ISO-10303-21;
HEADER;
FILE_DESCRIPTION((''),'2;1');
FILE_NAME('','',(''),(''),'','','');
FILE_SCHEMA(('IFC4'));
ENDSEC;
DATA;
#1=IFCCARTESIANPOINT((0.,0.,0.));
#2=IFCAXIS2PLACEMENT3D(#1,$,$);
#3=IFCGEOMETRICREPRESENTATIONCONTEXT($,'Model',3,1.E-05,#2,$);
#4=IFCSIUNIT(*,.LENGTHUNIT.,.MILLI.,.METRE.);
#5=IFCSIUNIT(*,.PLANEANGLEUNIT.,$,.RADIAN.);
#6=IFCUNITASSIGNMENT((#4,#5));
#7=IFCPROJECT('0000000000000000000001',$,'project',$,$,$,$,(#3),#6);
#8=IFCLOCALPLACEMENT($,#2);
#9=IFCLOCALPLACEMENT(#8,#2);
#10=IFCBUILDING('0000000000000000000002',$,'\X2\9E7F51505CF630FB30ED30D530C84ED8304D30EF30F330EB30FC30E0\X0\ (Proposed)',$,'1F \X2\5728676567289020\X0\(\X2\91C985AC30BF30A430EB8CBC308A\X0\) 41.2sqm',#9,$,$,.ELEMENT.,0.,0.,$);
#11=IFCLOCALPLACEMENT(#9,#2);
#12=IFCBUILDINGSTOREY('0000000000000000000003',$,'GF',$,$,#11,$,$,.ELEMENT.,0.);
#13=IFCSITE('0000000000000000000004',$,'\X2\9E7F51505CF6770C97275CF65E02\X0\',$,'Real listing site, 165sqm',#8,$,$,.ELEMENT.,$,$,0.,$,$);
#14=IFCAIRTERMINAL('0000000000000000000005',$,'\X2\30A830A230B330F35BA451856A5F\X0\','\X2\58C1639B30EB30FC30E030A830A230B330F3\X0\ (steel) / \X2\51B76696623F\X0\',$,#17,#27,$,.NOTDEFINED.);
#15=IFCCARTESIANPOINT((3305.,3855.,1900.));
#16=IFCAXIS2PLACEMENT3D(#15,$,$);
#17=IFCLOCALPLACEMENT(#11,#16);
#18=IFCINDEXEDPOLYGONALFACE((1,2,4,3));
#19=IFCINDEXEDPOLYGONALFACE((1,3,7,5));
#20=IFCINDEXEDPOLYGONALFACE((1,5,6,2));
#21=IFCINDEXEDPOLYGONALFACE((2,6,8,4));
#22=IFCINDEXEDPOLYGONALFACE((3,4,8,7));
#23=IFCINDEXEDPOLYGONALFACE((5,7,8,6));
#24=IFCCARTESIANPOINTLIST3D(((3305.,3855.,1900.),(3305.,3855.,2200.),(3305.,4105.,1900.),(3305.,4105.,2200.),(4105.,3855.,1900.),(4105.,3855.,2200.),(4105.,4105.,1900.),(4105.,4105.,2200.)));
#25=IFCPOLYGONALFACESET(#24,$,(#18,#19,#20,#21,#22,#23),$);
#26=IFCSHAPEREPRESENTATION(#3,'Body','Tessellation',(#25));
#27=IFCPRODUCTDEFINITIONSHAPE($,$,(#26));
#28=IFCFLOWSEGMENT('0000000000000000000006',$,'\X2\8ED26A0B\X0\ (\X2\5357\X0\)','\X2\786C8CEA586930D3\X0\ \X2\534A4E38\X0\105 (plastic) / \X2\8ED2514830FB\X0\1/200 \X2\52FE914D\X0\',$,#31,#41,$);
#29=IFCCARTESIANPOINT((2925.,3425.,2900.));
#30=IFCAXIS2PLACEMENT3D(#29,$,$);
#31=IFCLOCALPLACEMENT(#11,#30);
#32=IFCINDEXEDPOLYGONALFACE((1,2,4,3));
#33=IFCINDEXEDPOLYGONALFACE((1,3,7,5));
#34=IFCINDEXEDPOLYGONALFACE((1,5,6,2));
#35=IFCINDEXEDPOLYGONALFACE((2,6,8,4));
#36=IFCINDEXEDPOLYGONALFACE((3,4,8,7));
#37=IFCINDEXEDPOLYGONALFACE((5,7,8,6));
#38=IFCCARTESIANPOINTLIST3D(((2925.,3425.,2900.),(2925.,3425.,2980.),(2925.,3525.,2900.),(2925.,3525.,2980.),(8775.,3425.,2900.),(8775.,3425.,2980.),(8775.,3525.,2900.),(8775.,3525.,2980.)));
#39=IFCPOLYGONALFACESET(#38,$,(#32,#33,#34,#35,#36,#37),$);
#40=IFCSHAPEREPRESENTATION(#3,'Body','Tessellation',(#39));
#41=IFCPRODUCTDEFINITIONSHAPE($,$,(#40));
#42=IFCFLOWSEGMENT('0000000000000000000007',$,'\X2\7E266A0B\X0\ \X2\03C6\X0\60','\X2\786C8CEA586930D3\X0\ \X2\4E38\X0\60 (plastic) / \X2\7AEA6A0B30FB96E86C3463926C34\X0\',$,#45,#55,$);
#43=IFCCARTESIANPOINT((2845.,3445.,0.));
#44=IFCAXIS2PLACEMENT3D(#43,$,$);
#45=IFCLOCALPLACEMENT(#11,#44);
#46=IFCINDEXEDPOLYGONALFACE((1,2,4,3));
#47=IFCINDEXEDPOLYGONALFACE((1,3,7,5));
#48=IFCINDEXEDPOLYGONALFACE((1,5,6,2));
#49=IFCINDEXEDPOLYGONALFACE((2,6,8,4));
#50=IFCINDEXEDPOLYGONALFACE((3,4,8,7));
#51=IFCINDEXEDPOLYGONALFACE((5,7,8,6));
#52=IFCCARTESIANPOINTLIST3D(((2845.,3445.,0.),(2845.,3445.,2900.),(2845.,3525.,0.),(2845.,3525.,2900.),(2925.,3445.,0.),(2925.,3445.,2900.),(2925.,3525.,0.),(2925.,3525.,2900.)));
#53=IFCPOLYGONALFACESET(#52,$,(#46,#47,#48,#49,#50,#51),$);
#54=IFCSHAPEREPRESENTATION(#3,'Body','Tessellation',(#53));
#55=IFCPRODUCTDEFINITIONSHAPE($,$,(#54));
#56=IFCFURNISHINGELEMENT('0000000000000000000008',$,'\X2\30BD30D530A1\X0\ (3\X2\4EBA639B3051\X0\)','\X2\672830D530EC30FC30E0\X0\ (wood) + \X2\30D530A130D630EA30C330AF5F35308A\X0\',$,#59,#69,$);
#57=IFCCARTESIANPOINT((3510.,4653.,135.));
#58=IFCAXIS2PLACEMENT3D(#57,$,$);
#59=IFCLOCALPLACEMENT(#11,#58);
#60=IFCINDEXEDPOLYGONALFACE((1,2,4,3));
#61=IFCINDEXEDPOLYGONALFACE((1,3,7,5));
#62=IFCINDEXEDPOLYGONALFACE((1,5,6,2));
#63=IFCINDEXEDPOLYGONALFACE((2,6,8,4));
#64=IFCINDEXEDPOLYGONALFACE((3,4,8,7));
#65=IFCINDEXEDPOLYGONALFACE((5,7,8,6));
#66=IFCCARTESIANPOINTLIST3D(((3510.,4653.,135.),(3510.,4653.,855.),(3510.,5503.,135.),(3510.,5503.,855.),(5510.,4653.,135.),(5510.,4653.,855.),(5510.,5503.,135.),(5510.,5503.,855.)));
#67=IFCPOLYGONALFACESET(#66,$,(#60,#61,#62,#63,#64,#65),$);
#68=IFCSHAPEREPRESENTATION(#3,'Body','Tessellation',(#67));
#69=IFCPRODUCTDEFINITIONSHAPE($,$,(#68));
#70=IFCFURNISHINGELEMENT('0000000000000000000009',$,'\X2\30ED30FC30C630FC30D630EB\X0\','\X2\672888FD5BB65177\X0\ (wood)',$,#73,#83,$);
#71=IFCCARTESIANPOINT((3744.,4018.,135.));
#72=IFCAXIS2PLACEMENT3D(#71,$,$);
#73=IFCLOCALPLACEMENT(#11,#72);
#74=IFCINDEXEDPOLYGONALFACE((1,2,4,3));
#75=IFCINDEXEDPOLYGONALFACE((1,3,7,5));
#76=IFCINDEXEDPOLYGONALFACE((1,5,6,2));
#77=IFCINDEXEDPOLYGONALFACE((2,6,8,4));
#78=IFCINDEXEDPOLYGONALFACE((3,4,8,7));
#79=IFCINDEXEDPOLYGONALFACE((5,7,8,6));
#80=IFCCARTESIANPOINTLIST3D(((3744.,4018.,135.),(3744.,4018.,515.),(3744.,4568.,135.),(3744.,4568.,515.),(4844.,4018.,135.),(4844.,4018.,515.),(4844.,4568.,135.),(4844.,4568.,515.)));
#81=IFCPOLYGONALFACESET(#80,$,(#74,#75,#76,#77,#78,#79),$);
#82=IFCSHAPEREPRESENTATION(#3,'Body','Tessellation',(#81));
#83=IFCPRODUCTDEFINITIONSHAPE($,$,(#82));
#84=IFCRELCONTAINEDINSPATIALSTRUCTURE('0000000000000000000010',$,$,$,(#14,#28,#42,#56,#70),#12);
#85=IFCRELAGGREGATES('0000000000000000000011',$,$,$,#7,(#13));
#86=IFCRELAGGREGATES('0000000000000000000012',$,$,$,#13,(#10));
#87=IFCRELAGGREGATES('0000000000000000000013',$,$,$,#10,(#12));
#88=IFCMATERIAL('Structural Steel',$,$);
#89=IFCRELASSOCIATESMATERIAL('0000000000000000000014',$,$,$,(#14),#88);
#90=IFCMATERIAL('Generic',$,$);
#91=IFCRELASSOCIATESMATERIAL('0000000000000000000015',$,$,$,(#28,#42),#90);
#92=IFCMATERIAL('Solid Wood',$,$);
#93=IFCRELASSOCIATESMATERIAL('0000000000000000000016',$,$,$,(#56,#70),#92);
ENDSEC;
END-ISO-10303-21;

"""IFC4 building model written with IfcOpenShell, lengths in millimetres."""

from ifc_helpers import new_model, si_unit, frame, frame_2d, origin, place, context, project, spatial, rectangle, extrude, material, element, save


model = new_model("IFC4")

# Units and contexts
model_context = context("Model", 3, precision=1e-05, world=origin())
ifc_project = project(units=[si_unit("LENGTHUNIT", "METRE", prefix="MILLI"), si_unit("PLANEANGLEUNIT", "RADIAN")], contexts=[model_context])

# Site, building, storey
site_placement = place(None, origin())
site = spatial("IfcSite", under=ifc_project, at=site_placement, Name="鹿児島県霧島市", ObjectType="Real listing site, 165sqm", CompositionType="ELEMENT", RefElevation=0.0)
building_placement = place(site_placement, origin())
building = spatial("IfcBuilding", under=site, at=building_placement, Name="鹿児島・ロフト付きワンルーム (Proposed)", ObjectType="1F 在来木造(釉薬タイル貼り) 41.2sqm", CompositionType="ELEMENT", ElevationOfRefHeight=0.0, ElevationOfTerrain=0.0)
storey_placement = place(building_placement, origin())
storey = spatial("IfcBuildingStorey", under=building, at=storey_placement, Name="GF", CompositionType="ELEMENT", Elevation=0.0)

# Shared definitions
ifc_material_1 = material(Name="Solid Wood")

# Shared definitions
ifc_material_2 = material(Name="Structural Steel")

# Shared definitions
ifc_material_3 = material(Name="Generic")

# Air terminal
air_terminal_placement = place(storey_placement, frame((3305.0, 3855.0, 1900.0)))
element("IfcAirTerminal", 1, at=air_terminal_placement, inside=storey, material=ifc_material_2, Name="エアコン室内機", Description="壁掛ルームエアコン (steel) / 冷暖房", PredefinedType="NOTDEFINED", context=model_context, shape_type="SweptSolid", body=[
    extrude(rectangle(XDim=800.0, YDim=250.0, at=frame_2d((400.0, 125.0))), frame((3305.0, 3855.0, 1900.0)), (0.0, 0.0, 1.0), 300.0),
])

# Flow segments
flow_segment_1_placement = place(storey_placement, frame((2925.0, 3425.0, 2900.0)))
element("IfcFlowSegment", 2, at=flow_segment_1_placement, inside=storey, material=ifc_material_3, Name="軒樋 (南)", Description="硬質塩ビ 半丸105 (plastic) / 軒先・1/200 勾配", context=model_context, shape_type="SweptSolid", body=[
    extrude(rectangle(XDim=5850.0, YDim=100.0, at=frame_2d((2925.0, 50.0))), frame((2925.0, 3425.0, 2900.0)), (0.0, 0.0, 1.0), 80.0),
])
flow_segment_2_placement = place(storey_placement, frame((2845.0, 3445.0, 0.0)))
element("IfcFlowSegment", 3, at=flow_segment_2_placement, inside=storey, material=ifc_material_3, Name="縦樋 φ60", Description="硬質塩ビ 丸60 (plastic) / 竪樋・雨水排水", context=model_context, shape_type="SweptSolid", body=[
    extrude(rectangle(XDim=80.0, YDim=80.0, at=frame_2d((40.0, 40.0))), frame((2845.0, 3445.0, 0.0)), (0.0, 0.0, 1.0), 2900.0),
])

# Furnishing elements
furnishing_1_placement = place(storey_placement, frame((3510.0, 4653.0, 135.0)))
element("IfcFurnishingElement", 4, at=furnishing_1_placement, inside=storey, material=ifc_material_1, Name="ソファ (3人掛け)", Description="木フレーム (wood) + ファブリック張り", context=model_context, shape_type="SweptSolid", body=[
    extrude(rectangle(XDim=2000.0, YDim=850.0, at=frame_2d((1000.0, 425.0))), frame((3510.0, 4653.0, 135.0)), (0.0, 0.0, 1.0), 720.0),
])
furnishing_2_placement = place(storey_placement, frame((3744.0, 4018.0, 135.0)))
element("IfcFurnishingElement", 5, at=furnishing_2_placement, inside=storey, material=ifc_material_1, Name="ローテーブル", Description="木製家具 (wood)", context=model_context, shape_type="SweptSolid", body=[
    extrude(rectangle(XDim=1100.0, YDim=550.0, at=frame_2d((550.0, 275.0))), frame((3744.0, 4018.0, 135.0)), (0.0, 0.0, 1.0), 380.0),
])

save(model, "model.ifc")
